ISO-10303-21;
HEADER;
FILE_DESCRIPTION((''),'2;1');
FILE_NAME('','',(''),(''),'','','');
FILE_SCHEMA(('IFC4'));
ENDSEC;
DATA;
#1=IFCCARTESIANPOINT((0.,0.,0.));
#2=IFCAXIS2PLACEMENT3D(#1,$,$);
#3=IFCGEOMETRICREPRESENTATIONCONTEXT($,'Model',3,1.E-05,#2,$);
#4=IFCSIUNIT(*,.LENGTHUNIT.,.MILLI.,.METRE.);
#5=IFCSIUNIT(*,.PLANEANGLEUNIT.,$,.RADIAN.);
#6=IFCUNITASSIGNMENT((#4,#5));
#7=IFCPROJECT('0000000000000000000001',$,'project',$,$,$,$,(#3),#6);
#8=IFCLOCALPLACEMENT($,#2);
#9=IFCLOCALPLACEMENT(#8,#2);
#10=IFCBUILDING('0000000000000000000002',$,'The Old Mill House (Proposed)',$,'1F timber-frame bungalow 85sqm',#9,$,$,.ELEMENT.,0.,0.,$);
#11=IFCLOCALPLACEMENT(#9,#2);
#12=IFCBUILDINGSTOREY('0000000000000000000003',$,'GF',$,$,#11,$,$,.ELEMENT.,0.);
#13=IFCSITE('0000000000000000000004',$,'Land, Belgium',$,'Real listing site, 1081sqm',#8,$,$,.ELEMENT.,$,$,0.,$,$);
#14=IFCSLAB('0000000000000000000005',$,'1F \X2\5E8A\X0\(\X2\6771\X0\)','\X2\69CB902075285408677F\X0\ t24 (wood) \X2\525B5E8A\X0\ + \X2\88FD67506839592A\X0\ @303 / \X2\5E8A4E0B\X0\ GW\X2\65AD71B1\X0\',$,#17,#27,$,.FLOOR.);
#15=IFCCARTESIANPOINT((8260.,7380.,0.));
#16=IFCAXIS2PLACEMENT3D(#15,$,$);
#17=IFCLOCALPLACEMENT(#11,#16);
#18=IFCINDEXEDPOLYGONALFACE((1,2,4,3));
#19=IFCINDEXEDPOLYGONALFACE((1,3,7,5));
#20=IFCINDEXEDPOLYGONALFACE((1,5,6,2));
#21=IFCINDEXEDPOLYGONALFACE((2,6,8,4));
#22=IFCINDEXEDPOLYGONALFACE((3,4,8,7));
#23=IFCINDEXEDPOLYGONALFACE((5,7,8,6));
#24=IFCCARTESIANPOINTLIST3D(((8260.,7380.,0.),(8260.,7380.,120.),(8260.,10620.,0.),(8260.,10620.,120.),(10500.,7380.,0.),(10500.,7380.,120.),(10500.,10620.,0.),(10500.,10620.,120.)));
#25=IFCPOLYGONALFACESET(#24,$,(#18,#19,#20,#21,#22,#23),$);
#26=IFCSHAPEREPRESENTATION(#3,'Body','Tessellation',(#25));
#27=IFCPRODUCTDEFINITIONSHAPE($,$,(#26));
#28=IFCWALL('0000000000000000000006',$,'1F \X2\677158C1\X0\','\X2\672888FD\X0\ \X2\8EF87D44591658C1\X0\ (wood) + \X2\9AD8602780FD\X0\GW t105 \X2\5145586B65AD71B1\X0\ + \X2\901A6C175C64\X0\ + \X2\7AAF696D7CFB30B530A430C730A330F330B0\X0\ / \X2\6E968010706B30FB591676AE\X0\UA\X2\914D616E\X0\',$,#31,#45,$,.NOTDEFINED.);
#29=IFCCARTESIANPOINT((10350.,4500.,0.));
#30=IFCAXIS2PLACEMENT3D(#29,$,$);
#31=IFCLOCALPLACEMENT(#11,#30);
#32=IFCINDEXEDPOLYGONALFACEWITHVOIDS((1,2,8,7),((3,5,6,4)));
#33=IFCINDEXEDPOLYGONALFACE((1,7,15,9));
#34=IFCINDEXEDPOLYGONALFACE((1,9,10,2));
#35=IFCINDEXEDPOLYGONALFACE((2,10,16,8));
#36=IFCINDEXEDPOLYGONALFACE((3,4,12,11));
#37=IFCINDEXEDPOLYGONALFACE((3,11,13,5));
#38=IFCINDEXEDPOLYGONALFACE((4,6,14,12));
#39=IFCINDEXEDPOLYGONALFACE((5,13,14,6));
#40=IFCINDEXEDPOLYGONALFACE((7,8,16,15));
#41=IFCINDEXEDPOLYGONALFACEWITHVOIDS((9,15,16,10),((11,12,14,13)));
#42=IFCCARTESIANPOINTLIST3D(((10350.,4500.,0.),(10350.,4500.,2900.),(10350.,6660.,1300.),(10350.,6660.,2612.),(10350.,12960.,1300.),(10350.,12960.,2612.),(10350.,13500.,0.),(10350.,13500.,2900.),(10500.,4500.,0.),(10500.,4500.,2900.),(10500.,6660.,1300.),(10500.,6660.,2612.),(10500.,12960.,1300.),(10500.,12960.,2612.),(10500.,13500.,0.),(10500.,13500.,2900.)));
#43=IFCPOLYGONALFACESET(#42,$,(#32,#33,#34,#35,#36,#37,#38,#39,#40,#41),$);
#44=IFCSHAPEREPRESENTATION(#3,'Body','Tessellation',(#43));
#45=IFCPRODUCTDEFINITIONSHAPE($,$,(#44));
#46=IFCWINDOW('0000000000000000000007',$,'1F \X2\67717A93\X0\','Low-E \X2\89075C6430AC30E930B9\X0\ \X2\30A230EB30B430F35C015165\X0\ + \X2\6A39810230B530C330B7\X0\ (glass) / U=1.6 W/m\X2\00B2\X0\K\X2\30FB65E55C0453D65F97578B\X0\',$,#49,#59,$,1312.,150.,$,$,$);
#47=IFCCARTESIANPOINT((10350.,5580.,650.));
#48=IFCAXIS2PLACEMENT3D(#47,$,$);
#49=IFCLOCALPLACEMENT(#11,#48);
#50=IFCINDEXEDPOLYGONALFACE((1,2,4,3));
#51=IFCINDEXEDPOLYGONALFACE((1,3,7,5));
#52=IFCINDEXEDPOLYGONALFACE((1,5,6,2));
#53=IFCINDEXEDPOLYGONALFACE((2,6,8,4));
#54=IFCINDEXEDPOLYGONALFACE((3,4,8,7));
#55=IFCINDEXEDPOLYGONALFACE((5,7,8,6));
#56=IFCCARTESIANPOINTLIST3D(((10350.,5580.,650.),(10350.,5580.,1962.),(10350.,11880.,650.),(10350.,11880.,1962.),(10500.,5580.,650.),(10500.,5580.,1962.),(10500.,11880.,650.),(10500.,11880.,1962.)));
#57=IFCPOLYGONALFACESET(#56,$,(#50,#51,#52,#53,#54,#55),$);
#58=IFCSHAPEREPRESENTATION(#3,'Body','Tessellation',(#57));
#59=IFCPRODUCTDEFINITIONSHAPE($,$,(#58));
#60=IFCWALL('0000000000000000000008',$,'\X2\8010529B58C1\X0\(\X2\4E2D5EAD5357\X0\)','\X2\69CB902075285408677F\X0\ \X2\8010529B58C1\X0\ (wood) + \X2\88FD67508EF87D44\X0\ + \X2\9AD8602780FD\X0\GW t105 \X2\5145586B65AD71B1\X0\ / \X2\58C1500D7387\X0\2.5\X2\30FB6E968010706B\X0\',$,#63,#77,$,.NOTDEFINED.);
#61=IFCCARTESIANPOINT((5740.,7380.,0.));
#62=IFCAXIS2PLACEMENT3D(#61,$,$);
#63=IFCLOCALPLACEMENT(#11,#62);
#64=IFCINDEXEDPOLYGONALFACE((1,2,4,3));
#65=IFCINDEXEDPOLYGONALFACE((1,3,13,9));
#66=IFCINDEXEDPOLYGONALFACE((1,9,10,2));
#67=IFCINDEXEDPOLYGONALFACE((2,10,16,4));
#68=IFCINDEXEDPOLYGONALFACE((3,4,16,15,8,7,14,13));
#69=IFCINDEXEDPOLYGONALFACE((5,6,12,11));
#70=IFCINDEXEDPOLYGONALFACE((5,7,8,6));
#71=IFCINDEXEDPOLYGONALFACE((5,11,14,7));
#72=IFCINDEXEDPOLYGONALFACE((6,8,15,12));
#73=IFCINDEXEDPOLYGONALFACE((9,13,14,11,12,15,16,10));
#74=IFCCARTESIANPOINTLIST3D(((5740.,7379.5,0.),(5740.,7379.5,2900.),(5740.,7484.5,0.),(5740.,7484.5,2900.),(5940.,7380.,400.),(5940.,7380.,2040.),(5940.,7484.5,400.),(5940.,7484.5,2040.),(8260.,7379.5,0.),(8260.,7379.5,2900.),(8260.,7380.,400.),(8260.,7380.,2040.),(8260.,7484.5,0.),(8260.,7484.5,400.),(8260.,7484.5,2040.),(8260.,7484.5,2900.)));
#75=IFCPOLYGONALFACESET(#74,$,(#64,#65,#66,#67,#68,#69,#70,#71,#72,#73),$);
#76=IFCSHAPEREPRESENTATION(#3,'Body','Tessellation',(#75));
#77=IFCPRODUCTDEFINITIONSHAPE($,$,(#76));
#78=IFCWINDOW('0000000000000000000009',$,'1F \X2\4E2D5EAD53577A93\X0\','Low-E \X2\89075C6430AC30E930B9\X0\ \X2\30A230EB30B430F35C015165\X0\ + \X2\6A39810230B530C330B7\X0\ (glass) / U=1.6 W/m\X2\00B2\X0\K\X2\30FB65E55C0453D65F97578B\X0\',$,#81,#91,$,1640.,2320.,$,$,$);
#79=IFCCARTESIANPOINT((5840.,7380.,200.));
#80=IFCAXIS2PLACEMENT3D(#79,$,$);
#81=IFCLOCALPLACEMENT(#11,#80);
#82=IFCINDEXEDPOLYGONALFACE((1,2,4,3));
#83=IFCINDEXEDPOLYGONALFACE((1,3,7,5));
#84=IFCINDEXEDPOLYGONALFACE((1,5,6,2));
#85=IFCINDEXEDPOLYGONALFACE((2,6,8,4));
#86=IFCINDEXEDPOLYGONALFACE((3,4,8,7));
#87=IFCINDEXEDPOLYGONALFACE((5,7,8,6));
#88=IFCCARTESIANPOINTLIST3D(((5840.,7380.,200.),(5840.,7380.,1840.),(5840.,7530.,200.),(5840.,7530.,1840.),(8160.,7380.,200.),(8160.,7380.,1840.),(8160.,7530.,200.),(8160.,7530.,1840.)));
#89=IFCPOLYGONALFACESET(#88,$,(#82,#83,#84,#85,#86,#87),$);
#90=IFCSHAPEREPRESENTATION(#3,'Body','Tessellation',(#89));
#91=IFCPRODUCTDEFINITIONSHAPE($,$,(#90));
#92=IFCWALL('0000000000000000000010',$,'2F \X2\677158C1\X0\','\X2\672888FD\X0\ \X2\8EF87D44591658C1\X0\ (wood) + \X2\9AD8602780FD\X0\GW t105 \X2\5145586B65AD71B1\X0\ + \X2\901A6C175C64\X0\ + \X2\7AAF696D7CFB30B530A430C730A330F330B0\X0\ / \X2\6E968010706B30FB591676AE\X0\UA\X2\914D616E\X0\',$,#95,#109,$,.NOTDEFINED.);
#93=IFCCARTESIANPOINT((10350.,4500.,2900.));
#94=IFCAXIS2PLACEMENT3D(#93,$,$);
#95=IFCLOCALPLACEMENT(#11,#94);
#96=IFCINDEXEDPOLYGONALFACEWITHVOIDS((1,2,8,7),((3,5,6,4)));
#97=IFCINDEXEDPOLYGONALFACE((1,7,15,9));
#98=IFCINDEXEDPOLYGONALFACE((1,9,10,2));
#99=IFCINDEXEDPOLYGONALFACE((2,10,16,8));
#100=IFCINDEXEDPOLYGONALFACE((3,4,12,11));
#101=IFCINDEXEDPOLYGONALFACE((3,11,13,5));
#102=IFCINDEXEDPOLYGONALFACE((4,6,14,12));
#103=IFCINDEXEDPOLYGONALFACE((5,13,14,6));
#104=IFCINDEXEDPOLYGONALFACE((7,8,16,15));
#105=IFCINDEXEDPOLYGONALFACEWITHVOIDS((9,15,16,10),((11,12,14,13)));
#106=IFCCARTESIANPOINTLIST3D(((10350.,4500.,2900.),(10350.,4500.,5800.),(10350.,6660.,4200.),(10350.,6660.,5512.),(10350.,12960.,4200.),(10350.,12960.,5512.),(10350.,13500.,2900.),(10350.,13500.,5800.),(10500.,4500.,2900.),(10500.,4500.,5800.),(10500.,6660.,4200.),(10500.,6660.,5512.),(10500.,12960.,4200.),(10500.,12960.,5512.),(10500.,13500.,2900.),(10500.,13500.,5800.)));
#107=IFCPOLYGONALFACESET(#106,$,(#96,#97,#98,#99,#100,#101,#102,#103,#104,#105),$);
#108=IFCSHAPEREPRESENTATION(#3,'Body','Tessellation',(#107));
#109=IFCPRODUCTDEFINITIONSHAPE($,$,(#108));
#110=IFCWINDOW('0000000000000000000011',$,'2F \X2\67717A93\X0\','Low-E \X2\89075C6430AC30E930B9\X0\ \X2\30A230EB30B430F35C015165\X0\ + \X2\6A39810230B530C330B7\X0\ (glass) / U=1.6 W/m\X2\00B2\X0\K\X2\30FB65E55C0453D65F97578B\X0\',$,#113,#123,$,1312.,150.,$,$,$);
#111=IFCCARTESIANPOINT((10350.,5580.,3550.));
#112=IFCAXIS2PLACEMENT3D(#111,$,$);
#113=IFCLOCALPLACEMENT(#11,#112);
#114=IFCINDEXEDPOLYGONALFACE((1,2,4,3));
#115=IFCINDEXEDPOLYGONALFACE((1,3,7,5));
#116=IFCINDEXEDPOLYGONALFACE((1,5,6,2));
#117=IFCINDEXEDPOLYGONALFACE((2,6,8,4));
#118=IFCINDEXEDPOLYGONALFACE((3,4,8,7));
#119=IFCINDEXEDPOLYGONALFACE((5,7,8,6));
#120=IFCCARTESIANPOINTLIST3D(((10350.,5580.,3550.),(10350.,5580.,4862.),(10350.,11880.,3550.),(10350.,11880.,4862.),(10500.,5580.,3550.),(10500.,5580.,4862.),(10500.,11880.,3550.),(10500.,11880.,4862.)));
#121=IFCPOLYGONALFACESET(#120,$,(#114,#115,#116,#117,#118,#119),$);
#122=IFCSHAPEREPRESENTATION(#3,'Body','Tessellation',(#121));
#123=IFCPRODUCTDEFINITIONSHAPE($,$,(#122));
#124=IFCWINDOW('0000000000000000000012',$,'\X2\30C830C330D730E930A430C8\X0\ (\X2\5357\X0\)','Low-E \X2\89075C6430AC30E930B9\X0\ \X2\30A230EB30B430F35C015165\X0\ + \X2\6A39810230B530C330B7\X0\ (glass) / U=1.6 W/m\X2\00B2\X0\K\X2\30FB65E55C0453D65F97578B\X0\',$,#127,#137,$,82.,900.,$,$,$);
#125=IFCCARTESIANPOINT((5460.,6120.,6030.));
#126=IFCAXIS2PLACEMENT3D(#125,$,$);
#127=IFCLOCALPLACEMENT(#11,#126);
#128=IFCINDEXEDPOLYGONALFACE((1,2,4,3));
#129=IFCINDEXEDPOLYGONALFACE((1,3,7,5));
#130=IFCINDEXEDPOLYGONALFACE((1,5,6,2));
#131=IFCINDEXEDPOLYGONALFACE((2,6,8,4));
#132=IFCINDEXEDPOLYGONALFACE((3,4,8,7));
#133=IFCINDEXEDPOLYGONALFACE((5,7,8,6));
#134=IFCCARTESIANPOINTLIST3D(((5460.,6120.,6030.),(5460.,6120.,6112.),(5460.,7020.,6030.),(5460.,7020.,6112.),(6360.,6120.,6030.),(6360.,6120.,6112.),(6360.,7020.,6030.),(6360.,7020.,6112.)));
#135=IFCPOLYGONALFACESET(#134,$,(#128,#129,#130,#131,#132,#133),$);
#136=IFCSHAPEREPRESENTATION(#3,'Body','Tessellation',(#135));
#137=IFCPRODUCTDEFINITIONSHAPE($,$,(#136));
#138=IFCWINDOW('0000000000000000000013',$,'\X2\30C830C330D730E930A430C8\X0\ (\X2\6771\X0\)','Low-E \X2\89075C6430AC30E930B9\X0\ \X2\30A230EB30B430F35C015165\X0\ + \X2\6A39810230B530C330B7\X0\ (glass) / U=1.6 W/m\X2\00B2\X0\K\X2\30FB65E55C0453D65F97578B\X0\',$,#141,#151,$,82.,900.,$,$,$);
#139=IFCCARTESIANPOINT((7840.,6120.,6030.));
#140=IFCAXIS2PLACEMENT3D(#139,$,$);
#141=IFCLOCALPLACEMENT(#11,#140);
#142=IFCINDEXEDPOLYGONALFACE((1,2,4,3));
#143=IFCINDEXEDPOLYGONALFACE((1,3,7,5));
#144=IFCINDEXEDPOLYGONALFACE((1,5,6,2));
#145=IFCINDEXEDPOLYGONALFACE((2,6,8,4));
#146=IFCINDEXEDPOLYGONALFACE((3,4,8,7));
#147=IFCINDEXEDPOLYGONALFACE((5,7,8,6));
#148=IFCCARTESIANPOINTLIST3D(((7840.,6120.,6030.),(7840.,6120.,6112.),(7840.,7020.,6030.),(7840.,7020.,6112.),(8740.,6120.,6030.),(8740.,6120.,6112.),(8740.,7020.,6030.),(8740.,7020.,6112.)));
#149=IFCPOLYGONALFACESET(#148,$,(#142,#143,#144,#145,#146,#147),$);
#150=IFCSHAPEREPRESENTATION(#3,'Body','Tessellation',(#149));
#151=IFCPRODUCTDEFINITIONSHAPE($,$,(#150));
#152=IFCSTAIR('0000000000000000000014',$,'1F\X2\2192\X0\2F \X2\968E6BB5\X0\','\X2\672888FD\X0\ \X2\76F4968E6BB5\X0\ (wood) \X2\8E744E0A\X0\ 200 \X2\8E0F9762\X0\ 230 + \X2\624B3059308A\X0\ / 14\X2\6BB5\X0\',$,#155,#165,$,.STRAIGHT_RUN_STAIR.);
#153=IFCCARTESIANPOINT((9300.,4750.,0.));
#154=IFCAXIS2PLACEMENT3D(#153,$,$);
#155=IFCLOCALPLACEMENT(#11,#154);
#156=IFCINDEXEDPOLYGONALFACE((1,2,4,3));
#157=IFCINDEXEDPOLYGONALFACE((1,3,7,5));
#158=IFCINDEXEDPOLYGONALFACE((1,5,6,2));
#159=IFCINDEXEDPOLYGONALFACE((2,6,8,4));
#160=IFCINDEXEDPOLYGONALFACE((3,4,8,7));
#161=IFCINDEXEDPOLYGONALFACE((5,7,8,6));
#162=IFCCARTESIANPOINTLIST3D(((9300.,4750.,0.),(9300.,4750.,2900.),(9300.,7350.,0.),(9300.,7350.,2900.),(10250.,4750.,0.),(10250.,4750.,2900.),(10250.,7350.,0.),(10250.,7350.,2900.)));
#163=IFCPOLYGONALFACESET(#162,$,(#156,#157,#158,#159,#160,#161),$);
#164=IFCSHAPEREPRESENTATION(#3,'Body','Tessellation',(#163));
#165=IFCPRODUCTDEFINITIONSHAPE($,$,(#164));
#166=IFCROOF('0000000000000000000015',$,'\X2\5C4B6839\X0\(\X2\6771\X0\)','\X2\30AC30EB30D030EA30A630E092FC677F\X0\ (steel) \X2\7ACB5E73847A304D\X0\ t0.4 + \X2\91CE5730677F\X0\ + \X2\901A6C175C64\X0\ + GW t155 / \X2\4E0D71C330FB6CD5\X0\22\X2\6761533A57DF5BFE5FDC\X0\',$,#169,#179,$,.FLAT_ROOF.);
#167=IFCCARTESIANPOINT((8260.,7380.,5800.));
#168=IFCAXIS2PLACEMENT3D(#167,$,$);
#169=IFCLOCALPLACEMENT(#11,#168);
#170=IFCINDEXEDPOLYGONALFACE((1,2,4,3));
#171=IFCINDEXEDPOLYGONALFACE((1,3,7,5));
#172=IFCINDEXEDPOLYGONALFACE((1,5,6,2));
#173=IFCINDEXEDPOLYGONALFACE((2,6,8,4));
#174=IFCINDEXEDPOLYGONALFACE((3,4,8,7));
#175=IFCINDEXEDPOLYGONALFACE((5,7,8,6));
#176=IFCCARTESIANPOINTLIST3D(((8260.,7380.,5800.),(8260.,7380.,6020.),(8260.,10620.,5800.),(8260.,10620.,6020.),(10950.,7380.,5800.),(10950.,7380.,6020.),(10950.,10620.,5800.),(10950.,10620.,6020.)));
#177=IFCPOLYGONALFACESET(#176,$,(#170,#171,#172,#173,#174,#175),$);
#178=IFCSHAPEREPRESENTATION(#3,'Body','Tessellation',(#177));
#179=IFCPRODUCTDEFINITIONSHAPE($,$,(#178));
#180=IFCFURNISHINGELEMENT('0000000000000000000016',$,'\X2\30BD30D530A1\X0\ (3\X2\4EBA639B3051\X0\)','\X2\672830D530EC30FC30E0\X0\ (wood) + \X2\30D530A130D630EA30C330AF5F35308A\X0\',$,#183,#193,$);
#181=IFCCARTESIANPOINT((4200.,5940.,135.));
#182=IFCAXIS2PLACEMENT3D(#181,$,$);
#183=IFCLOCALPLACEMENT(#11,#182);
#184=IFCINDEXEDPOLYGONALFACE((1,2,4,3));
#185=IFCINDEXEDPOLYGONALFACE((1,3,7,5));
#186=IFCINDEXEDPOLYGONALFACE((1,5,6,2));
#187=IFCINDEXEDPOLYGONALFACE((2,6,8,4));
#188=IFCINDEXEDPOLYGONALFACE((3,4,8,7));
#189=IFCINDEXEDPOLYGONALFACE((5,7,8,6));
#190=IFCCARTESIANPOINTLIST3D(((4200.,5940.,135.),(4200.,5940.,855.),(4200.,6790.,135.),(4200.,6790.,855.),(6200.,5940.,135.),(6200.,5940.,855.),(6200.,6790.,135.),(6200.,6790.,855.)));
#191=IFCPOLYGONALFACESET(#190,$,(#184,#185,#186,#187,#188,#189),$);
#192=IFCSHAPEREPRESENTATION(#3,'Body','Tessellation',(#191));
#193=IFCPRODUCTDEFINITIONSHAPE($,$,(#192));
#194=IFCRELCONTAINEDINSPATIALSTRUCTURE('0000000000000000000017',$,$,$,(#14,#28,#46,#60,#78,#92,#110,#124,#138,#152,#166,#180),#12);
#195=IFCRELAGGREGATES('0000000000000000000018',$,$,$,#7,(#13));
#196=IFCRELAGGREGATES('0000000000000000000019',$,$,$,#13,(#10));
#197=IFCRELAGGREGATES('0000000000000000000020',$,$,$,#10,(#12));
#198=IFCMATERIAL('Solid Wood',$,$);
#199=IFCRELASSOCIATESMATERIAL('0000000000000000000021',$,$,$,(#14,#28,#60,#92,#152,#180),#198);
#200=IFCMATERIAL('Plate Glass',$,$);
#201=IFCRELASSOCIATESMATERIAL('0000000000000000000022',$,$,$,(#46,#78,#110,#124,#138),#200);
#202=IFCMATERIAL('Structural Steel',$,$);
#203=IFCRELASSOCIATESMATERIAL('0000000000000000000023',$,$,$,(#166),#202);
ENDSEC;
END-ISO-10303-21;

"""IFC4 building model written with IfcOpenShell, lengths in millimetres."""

from ifc_helpers import new_model, si_unit, frame, frame_2d, origin, place, context, project, spatial, rectangle, extrude, material, element, fill, save


model = new_model("IFC4")

# Units and contexts
model_context = context("Model", 3, precision=1e-05, world=origin())
ifc_project = project(units=[si_unit("LENGTHUNIT", "METRE", prefix="MILLI"), si_unit("PLANEANGLEUNIT", "RADIAN")], contexts=[model_context])

# Site, building, storey
site_placement = place(None, origin())
site = spatial("IfcSite", under=ifc_project, at=site_placement, Name="Land, Belgium", ObjectType="Real listing site, 1081sqm", CompositionType="ELEMENT", RefElevation=0.0)
building_placement = place(site_placement, origin())
building = spatial("IfcBuilding", under=site, at=building_placement, Name="The Old Mill House (Proposed)", ObjectType="1F timber-frame bungalow 85sqm", CompositionType="ELEMENT", ElevationOfRefHeight=0.0, ElevationOfTerrain=0.0)
storey_placement = place(building_placement, origin())
storey = spatial("IfcBuildingStorey", under=building, at=storey_placement, Name="GF", CompositionType="ELEMENT", Elevation=0.0)

# Slab
ifc_material_1 = material(Name="Solid Wood")
slab_placement = place(storey_placement, frame((8260.0, 7380.0, 0.0)))
element("IfcSlab", 1, at=slab_placement, inside=storey, material=ifc_material_1, Name="1F 床(東)", Description="構造用合板 t24 (wood) 剛床 + 製材根太 @303 / 床下 GW断熱", PredefinedType="FLOOR", context=model_context, shape_type="SweptSolid", body=[
    extrude(rectangle(XDim=2240.0, YDim=3240.0, at=frame_2d((1120.0, 1620.0))), frame((8260.0, 7380.0, 0.0)), (0.0, 0.0, 1.0), 120.0),
])

# Walls, openings, windows
wall_1_placement = place(storey_placement, frame((10350.0, 4500.0, 0.0)))
wall_1 = element("IfcWall", 2, at=wall_1_placement, inside=storey, material=ifc_material_1, Name="1F 東壁", Description="木製 軸組外壁 (wood) + 高性能GW t105 充填断熱 + 通気層 + 窯業系サイディング / 準耐火・外皮UA配慮", PredefinedType="NOTDEFINED", context=model_context, shape_type="SweptSolid", body=[
    extrude(rectangle(XDim=150.0, YDim=9000.0, at=frame_2d((75.0, 4500.0))), frame((10350.0, 4500.0, 0.0)), (0.0, 0.0, 1.0), 2900.0),
])
opening_1_placement = place(storey_placement, frame((10350.0, 5580.0, 650.0)))
opening_1 = element("IfcOpeningElement", 3, at=opening_1_placement, cuts=wall_1, PredefinedType="NOTDEFINED", context=model_context, shape_type="SweptSolid", body=[
    extrude(rectangle(XDim=150.0, YDim=6300.0, at=frame_2d((75.0, 3150.0))), frame((10350.0, 5580.0, 650.0)), (0.0, 0.0, 1.0), 1312.0),
])
ifc_material_2 = material(Name="Plate Glass")
window_1_placement = place(storey_placement, frame((10350.0, 5580.0, 650.0)))
window_1 = element("IfcWindow", 4, at=window_1_placement, inside=storey, material=ifc_material_2, Name="1F 東窓", Description="Low-E 複層ガラス アルゴン封入 + 樹脂サッシ (glass) / U=1.6 W/m²K・日射取得型", OverallHeight=1312.0, OverallWidth=150.0, context=model_context, shape_type="SweptSolid", body=[
    extrude(rectangle(XDim=150.0, YDim=6300.0, at=frame_2d((75.0, 3150.0))), frame((10350.0, 5580.0, 650.0)), (0.0, 0.0, 1.0), 1312.0),
])
fill(opening_1, window_1)
wall_2_placement = place(storey_placement, frame((5740.0, 7380.0, 0.0)))
wall_2 = element("IfcWall", 5, at=wall_2_placement, inside=storey, material=ifc_material_1, Name="耐力壁(中庭南)", Description="構造用合板 耐力壁 (wood) + 製材軸組 + 高性能GW t105 充填断熱 / 壁倍率2.5・準耐火", PredefinedType="NOTDEFINED", context=model_context, shape_type="SweptSolid", body=[
    extrude(rectangle(XDim=2520.0, YDim=105.0, at=frame_2d((1260.0, 52.0))), frame((5740.0, 7380.0, 0.0)), (0.0, 0.0, 1.0), 2900.0),
])
opening_2_placement = place(storey_placement, frame((5840.0, 7380.0, 200.0)))
opening_2 = element("IfcOpeningElement", 6, at=opening_2_placement, cuts=wall_2, PredefinedType="NOTDEFINED", context=model_context, shape_type="SweptSolid", body=[
    extrude(rectangle(XDim=2320.0, YDim=150.0, at=frame_2d((1160.0, 75.0))), frame((5840.0, 7380.0, 200.0)), (0.0, 0.0, 1.0), 1640.0),
])
window_2_placement = place(storey_placement, frame((5840.0, 7380.0, 200.0)))
window_2 = element("IfcWindow", 7, at=window_2_placement, inside=storey, material=ifc_material_2, Name="1F 中庭南窓", Description="Low-E 複層ガラス アルゴン封入 + 樹脂サッシ (glass) / U=1.6 W/m²K・日射取得型", OverallHeight=1640.0, OverallWidth=2320.0, context=model_context, shape_type="SweptSolid", body=[
    extrude(rectangle(XDim=2320.0, YDim=150.0, at=frame_2d((1160.0, 75.0))), frame((5840.0, 7380.0, 200.0)), (0.0, 0.0, 1.0), 1640.0),
])
fill(opening_2, window_2)

# Wall, opening, window
wall_3_placement = place(storey_placement, frame((10350.0, 4500.0, 2900.0)))
wall_3 = element("IfcWall", 8, at=wall_3_placement, inside=storey, material=ifc_material_1, Name="2F 東壁", Description="木製 軸組外壁 (wood) + 高性能GW t105 充填断熱 + 通気層 + 窯業系サイディング / 準耐火・外皮UA配慮", PredefinedType="NOTDEFINED", context=model_context, shape_type="SweptSolid", body=[
    extrude(rectangle(XDim=150.0, YDim=9000.0, at=frame_2d((75.0, 4500.0))), frame((10350.0, 4500.0, 2900.0)), (0.0, 0.0, 1.0), 2900.0),
])
opening_3_placement = place(storey_placement, frame((10350.0, 5580.0, 3550.0)))
opening_3 = element("IfcOpeningElement", 9, at=opening_3_placement, cuts=wall_3, PredefinedType="NOTDEFINED", context=model_context, shape_type="SweptSolid", body=[
    extrude(rectangle(XDim=150.0, YDim=6300.0, at=frame_2d((75.0, 3150.0))), frame((10350.0, 5580.0, 3550.0)), (0.0, 0.0, 1.0), 1312.0),
])
window_3_placement = place(storey_placement, frame((10350.0, 5580.0, 3550.0)))
window_3 = element("IfcWindow", 10, at=window_3_placement, inside=storey, material=ifc_material_2, Name="2F 東窓", Description="Low-E 複層ガラス アルゴン封入 + 樹脂サッシ (glass) / U=1.6 W/m²K・日射取得型", OverallHeight=1312.0, OverallWidth=150.0, context=model_context, shape_type="SweptSolid", body=[
    extrude(rectangle(XDim=150.0, YDim=6300.0, at=frame_2d((75.0, 3150.0))), frame((10350.0, 5580.0, 3550.0)), (0.0, 0.0, 1.0), 1312.0),
])
fill(opening_3, window_3)

# Windows
window_4_placement = place(storey_placement, frame((5460.0, 6120.0, 6030.0)))
element("IfcWindow", 11, at=window_4_placement, inside=storey, material=ifc_material_2, Name="トップライト (南)", Description="Low-E 複層ガラス アルゴン封入 + 樹脂サッシ (glass) / U=1.6 W/m²K・日射取得型", OverallHeight=82.0, OverallWidth=900.0, context=model_context, shape_type="SweptSolid", body=[
    extrude(rectangle(XDim=900.0, YDim=900.0, at=frame_2d((450.0, 450.0))), frame((5460.0, 6120.0, 6030.0)), (0.0, 0.0, 1.0), 82.0),
])
window_5_placement = place(storey_placement, frame((7840.0, 6120.0, 6030.0)))
element("IfcWindow", 12, at=window_5_placement, inside=storey, material=ifc_material_2, Name="トップライト (東)", Description="Low-E 複層ガラス アルゴン封入 + 樹脂サッシ (glass) / U=1.6 W/m²K・日射取得型", OverallHeight=82.0, OverallWidth=900.0, context=model_context, shape_type="SweptSolid", body=[
    extrude(rectangle(XDim=900.0, YDim=900.0, at=frame_2d((450.0, 450.0))), frame((7840.0, 6120.0, 6030.0)), (0.0, 0.0, 1.0), 82.0),
])

# Stair
stair_placement = place(storey_placement, frame((9300.0, 4750.0, 0.0)))
element("IfcStair", 13, at=stair_placement, inside=storey, material=ifc_material_1, Name="1F→2F 階段", Description="木製 直階段 (wood) 蹴上 200 踏面 230 + 手すり / 14段", PredefinedType="STRAIGHT_RUN_STAIR", context=model_context, shape_type="SweptSolid", body=[
    extrude(rectangle(XDim=950.0, YDim=2600.0, at=frame_2d((475.0, 1300.0))), frame((9300.0, 4750.0, 0.0)), (0.0, 0.0, 1.0), 2900.0),
])

# Roof
ifc_material_3 = material(Name="Structural Steel")
roof_placement = place(storey_placement, frame((8260.0, 7380.0, 5800.0)))
element("IfcRoof", 14, at=roof_placement, inside=storey, material=ifc_material_3, Name="屋根(東)", Description="ガルバリウム鋼板 (steel) 立平葺き t0.4 + 野地板 + 通気層 + GW t155 / 不燃・法22条区域対応", PredefinedType="FLAT_ROOF", context=model_context, shape_type="SweptSolid", body=[
    extrude(rectangle(XDim=2690.0, YDim=3240.0, at=frame_2d((1345.0, 1620.0))), frame((8260.0, 7380.0, 5800.0)), (0.0, 0.0, 1.0), 220.0),
])

# Furnishing element
furnishing_1_placement = place(storey_placement, frame((4200.0, 5940.0, 135.0)))
element("IfcFurnishingElement", 15, at=furnishing_1_placement, inside=storey, material=ifc_material_1, Name="ソファ (3人掛け)", Description="木フレーム (wood) + ファブリック張り", context=model_context, shape_type="SweptSolid", body=[
    extrude(rectangle(XDim=2000.0, YDim=850.0, at=frame_2d((1000.0, 425.0))), frame((4200.0, 5940.0, 135.0)), (0.0, 0.0, 1.0), 720.0),
])

save(model, "model.ifc")
